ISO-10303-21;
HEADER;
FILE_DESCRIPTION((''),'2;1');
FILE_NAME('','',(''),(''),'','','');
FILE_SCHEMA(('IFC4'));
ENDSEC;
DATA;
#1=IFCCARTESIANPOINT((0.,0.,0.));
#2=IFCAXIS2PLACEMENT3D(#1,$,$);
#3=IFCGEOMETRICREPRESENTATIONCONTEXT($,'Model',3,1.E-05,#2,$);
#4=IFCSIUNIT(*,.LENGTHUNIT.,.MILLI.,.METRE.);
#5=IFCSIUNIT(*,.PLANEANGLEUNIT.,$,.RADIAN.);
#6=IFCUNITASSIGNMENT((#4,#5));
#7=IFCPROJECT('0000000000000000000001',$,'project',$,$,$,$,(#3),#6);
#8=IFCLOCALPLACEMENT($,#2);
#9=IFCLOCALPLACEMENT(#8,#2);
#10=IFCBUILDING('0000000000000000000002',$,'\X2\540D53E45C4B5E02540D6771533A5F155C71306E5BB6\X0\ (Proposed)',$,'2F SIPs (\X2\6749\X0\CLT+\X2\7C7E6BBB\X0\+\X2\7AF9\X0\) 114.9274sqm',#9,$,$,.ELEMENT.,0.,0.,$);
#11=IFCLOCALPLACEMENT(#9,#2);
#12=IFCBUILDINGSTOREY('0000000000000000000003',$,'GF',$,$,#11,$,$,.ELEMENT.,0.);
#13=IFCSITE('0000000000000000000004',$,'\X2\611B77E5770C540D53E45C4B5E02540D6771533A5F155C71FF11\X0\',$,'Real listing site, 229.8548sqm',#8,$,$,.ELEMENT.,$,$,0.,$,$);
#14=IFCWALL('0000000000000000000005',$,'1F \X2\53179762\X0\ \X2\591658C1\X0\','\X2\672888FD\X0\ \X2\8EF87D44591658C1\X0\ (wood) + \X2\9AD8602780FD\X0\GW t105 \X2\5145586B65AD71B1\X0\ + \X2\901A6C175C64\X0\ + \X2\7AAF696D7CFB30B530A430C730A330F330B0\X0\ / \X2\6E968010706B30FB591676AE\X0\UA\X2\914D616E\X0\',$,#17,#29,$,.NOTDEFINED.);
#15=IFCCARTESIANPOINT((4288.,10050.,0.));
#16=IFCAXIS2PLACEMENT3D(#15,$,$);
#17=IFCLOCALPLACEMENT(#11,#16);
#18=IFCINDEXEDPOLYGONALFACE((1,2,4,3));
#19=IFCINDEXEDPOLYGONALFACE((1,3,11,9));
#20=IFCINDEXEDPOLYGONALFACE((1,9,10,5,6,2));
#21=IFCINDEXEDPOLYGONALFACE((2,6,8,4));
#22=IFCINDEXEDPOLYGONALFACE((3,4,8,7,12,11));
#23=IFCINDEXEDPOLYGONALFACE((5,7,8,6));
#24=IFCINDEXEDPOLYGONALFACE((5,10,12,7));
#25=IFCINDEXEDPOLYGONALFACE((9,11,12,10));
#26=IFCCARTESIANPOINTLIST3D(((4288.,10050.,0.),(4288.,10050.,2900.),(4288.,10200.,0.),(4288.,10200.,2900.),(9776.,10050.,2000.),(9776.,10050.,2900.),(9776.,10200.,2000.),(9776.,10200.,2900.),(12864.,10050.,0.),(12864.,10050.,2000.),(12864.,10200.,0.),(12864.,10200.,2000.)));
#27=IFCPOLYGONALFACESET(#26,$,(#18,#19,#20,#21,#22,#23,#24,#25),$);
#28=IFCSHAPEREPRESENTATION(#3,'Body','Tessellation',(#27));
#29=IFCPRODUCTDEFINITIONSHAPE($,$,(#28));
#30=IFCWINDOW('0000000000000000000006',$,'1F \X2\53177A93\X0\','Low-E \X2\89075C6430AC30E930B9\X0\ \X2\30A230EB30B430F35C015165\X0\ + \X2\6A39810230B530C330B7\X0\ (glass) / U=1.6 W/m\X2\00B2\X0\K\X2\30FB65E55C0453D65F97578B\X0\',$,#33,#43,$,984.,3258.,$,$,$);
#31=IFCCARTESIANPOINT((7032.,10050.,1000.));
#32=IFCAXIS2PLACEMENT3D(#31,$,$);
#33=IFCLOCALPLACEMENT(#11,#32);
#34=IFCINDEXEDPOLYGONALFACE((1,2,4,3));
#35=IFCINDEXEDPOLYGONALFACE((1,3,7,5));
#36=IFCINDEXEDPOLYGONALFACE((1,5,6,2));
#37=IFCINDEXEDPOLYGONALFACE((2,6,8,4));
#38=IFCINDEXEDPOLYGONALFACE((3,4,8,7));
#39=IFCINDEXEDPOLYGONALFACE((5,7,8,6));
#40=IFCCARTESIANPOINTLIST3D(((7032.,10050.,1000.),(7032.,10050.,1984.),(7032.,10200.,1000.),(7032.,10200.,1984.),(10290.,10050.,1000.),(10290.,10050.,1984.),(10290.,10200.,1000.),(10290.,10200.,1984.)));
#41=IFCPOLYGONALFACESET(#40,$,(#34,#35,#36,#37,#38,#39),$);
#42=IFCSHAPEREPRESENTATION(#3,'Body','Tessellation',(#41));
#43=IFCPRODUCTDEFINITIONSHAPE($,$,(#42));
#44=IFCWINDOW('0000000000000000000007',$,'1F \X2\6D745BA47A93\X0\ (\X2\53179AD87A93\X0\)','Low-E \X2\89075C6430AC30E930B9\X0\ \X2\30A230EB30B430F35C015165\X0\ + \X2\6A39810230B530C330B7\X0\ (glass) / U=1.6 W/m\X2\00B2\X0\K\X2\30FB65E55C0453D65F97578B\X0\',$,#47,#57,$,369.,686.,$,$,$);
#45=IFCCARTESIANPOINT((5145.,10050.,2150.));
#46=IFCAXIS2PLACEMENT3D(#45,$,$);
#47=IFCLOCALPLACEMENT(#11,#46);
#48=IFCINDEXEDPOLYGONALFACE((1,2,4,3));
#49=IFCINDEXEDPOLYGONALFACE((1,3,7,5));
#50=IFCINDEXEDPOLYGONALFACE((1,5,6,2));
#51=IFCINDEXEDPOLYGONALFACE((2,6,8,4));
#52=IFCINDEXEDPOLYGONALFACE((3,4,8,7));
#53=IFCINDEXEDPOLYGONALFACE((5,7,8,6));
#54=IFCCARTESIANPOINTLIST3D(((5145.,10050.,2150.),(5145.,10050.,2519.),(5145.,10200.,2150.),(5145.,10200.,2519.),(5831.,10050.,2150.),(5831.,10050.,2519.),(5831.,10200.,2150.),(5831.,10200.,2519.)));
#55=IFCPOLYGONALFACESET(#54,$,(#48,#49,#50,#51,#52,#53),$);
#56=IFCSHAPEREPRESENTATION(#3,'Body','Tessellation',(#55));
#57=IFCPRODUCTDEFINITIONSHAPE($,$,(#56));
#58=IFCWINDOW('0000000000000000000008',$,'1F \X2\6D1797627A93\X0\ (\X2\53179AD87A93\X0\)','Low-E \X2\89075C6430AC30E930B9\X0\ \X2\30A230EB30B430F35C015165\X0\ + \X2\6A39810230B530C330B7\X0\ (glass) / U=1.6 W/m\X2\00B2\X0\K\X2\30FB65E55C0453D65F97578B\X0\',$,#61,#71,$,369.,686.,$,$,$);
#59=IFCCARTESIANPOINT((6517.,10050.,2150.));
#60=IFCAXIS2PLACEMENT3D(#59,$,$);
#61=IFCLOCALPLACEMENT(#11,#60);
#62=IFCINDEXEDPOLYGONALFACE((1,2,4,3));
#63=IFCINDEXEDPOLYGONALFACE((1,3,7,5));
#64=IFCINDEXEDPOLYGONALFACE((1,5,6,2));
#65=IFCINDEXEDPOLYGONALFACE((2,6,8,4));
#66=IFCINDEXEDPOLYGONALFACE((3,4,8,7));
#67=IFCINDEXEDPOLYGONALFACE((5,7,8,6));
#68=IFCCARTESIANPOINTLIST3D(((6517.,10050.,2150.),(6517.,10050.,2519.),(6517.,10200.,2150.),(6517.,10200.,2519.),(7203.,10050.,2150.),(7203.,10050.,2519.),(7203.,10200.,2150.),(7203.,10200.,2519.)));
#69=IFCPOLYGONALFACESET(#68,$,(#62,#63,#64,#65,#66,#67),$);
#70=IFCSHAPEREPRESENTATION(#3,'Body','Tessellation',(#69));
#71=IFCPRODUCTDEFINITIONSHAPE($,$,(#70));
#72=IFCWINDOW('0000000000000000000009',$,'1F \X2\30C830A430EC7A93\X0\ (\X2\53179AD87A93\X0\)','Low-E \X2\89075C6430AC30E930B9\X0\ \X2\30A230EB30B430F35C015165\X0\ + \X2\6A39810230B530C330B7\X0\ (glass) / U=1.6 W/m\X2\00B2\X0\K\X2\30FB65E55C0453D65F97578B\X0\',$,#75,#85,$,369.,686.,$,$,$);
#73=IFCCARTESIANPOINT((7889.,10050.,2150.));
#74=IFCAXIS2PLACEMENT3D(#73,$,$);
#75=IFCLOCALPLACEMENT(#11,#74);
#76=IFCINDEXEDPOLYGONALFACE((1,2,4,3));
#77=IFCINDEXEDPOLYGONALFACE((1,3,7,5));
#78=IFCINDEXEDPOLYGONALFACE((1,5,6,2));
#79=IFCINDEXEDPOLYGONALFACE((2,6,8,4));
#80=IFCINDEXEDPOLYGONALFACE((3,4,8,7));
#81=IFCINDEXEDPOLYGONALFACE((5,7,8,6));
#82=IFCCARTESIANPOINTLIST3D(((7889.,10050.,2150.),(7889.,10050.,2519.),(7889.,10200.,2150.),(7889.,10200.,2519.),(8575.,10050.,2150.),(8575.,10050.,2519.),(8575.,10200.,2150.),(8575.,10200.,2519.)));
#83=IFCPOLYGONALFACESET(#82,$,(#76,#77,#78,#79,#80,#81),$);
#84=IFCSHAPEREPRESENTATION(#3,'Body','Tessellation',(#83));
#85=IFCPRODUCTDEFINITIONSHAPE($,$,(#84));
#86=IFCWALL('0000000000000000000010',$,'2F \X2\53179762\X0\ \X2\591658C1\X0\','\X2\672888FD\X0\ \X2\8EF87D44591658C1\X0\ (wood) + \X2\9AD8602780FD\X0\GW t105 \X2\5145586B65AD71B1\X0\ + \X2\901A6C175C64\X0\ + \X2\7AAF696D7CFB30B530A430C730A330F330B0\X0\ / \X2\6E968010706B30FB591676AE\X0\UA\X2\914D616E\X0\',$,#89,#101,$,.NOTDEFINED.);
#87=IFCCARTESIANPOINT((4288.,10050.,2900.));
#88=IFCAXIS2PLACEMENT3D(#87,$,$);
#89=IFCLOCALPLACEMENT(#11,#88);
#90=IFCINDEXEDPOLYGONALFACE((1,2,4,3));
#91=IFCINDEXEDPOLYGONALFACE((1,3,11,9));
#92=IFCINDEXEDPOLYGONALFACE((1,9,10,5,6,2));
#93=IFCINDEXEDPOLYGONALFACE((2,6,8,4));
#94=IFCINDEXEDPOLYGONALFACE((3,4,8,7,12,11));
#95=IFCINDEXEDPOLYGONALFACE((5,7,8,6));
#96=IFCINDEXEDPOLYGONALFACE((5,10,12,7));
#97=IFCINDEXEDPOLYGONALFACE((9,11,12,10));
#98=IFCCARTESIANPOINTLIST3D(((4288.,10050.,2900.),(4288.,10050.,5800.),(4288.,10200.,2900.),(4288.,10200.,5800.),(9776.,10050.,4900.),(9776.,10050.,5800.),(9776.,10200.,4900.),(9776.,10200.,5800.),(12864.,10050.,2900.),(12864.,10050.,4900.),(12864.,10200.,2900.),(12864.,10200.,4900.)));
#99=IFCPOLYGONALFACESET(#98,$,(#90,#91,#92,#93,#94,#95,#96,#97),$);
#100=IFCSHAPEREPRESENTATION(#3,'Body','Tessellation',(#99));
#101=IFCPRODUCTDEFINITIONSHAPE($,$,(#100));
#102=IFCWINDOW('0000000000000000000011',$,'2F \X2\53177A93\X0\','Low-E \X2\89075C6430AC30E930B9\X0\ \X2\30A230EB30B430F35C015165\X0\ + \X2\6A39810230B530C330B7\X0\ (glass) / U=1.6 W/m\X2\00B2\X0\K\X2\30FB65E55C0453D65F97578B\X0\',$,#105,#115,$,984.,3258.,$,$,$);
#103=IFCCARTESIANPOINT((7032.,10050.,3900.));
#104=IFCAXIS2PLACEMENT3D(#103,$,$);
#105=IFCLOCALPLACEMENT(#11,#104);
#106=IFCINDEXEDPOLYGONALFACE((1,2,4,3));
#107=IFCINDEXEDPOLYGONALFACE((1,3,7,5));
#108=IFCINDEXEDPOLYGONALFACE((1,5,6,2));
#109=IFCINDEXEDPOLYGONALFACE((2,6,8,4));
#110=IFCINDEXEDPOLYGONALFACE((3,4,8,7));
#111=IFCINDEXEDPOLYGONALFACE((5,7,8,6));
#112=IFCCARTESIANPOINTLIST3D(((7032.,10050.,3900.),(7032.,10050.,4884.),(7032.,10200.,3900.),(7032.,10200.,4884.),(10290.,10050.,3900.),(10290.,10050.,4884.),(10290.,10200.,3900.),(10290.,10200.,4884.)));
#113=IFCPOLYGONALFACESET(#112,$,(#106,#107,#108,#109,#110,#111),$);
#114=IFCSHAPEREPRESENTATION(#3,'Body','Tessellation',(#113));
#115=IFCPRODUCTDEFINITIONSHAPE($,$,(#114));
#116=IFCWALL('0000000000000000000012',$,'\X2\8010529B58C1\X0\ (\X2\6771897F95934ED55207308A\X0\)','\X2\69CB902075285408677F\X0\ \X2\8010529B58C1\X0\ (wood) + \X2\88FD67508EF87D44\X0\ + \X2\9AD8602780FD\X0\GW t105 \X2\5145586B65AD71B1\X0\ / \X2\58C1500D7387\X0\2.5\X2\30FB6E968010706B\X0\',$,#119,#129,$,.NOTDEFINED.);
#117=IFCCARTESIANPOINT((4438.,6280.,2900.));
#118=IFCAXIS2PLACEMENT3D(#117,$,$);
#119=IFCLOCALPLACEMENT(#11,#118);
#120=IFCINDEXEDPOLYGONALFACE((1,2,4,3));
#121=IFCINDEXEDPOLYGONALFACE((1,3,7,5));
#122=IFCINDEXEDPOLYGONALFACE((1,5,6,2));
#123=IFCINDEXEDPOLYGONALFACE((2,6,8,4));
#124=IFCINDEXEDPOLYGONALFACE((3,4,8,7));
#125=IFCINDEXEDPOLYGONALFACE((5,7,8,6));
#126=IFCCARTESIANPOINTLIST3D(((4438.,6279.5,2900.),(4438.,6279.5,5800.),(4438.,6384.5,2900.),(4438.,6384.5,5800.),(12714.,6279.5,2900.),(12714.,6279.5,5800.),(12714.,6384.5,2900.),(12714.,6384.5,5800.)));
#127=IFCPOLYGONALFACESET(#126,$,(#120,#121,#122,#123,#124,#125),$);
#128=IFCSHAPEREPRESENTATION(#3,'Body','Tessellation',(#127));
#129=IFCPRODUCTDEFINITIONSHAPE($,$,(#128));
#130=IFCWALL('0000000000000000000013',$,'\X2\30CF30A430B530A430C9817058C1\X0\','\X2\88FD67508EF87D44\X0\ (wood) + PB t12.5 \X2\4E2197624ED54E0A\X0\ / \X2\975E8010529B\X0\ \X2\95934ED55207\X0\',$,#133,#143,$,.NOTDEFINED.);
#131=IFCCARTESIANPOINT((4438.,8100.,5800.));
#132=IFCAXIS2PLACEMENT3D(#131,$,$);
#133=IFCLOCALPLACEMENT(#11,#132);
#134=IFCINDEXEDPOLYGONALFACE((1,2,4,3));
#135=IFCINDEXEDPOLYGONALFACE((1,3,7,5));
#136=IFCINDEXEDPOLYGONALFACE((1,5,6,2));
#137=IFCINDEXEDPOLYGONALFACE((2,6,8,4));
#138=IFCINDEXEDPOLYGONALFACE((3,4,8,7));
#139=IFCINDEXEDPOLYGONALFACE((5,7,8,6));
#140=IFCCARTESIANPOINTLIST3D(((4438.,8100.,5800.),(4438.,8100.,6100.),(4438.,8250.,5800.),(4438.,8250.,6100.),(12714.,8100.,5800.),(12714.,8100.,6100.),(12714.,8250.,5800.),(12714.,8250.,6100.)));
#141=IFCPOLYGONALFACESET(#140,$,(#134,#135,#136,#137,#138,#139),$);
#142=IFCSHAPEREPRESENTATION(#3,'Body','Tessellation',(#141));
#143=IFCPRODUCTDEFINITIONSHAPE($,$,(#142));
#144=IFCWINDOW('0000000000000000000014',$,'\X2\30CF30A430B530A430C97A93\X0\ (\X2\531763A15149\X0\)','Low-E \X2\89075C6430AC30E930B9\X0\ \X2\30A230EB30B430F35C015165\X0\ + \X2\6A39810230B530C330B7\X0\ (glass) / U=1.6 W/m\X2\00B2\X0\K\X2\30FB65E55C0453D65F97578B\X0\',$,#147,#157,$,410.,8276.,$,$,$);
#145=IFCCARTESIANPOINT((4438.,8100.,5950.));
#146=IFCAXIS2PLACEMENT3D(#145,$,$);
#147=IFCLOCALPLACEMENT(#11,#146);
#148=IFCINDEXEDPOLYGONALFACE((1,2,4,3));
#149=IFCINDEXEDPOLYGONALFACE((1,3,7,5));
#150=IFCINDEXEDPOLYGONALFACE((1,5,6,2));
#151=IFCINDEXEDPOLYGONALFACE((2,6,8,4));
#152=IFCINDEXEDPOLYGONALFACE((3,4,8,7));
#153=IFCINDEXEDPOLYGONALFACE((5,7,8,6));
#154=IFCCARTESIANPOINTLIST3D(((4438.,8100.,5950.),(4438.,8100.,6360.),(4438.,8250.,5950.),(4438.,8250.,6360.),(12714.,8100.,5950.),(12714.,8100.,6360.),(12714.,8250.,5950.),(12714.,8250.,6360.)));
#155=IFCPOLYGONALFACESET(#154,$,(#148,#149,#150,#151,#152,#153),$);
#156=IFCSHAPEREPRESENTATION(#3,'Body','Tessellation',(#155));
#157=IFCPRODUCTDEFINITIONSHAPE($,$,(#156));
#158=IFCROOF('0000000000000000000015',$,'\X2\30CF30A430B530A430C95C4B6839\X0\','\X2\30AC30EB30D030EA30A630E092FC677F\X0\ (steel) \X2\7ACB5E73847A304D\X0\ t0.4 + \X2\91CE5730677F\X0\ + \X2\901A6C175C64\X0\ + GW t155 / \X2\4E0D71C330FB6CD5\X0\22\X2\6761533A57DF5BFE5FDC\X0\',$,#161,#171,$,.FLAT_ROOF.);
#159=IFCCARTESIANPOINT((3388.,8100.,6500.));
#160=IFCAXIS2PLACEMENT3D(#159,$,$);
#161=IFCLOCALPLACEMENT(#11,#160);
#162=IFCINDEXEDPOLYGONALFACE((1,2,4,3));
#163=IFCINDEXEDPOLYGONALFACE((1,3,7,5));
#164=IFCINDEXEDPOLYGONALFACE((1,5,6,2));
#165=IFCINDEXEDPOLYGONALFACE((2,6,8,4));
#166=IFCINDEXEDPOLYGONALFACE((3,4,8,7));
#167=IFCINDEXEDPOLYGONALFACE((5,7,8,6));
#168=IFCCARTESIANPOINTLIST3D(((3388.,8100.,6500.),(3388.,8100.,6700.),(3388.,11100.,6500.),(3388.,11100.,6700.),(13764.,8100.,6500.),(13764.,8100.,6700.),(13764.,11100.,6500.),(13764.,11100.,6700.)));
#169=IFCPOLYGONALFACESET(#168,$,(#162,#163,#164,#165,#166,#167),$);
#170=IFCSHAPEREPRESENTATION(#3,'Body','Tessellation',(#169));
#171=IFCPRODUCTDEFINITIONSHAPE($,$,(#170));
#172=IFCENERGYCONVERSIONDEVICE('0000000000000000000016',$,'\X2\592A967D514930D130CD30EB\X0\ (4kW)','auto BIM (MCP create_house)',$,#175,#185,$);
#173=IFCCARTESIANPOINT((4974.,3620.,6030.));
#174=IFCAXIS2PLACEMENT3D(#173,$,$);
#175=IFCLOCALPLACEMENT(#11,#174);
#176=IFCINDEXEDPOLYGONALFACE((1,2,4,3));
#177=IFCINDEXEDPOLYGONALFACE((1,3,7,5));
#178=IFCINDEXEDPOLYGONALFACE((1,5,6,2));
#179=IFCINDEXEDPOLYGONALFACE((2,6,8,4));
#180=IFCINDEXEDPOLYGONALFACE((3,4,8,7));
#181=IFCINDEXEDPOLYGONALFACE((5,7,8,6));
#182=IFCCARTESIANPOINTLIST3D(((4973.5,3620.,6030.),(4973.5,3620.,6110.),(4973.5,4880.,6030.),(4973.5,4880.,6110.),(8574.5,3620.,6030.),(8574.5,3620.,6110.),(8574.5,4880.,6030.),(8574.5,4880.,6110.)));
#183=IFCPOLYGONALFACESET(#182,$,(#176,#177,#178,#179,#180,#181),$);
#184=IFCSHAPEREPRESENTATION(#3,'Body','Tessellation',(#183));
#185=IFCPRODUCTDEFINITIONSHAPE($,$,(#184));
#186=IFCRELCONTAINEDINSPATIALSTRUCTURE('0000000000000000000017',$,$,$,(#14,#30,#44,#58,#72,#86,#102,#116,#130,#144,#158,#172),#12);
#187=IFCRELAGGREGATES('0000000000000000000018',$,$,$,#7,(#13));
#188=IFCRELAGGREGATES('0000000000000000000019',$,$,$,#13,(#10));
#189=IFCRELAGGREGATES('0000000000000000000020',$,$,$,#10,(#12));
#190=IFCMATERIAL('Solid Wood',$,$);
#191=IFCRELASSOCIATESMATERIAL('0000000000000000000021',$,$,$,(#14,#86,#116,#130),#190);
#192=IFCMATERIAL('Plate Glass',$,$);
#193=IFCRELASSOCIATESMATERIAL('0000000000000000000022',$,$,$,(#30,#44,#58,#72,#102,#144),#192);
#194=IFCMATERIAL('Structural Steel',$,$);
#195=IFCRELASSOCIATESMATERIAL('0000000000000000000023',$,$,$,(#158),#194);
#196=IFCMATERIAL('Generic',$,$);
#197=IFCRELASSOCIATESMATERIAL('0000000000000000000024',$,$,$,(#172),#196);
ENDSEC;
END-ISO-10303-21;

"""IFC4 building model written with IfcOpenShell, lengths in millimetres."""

from ifc_helpers import new_model, si_unit, frame, frame_2d, origin, place, context, project, spatial, rectangle, extrude, material, element, fill, save


model = new_model("IFC4")

# Units and contexts
model_context = context("Model", 3, precision=1e-05, world=origin())
ifc_project = project(units=[si_unit("LENGTHUNIT", "METRE", prefix="MILLI"), si_unit("PLANEANGLEUNIT", "RADIAN")], contexts=[model_context])

# Site, building, storey
site_placement = place(None, origin())
site = spatial("IfcSite", under=ifc_project, at=site_placement, Name="愛知県名古屋市名東区引山１", ObjectType="Real listing site, 229.8548sqm", CompositionType="ELEMENT", RefElevation=0.0)
building_placement = place(site_placement, origin())
building = spatial("IfcBuilding", under=site, at=building_placement, Name="名古屋市名東区引山の家 (Proposed)", ObjectType="2F SIPs (杉CLT+籾殻+竹) 114.9274sqm", CompositionType="ELEMENT", ElevationOfRefHeight=0.0, ElevationOfTerrain=0.0)
storey_placement = place(building_placement, origin())
storey = spatial("IfcBuildingStorey", under=building, at=storey_placement, Name="GF", CompositionType="ELEMENT", Elevation=0.0)

# Wall, openings, windows
ifc_material_1 = material(Name="Solid Wood")
wall_1_placement = place(storey_placement, frame((4288.0, 10050.0, 0.0)))
wall_1 = element("IfcWall", 1, at=wall_1_placement, inside=storey, material=ifc_material_1, Name="1F 北面 外壁", Description="木製 軸組外壁 (wood) + 高性能GW t105 充填断熱 + 通気層 + 窯業系サイディング / 準耐火・外皮UA配慮", PredefinedType="NOTDEFINED", context=model_context, shape_type="SweptSolid", body=[
    extrude(rectangle(XDim=8576.0, YDim=150.0, at=frame_2d((4288.0, 75.0))), frame((4288.0, 10050.0, 0.0)), (0.0, 0.0, 1.0), 2900.0),
])
opening_1_placement = place(storey_placement, frame((7032.0, 10050.0, 1000.0)))
opening_1 = element("IfcOpeningElement", 2, at=opening_1_placement, cuts=wall_1, PredefinedType="NOTDEFINED", context=model_context, shape_type="SweptSolid", body=[
    extrude(rectangle(XDim=3258.0, YDim=150.0, at=frame_2d((1629.0, 75.0))), frame((7032.0, 10050.0, 1000.0)), (0.0, 0.0, 1.0), 984.0),
])
opening_2_placement = place(storey_placement, frame((5145.0, 10050.0, 2150.0)))
opening_2 = element("IfcOpeningElement", 3, at=opening_2_placement, cuts=wall_1, PredefinedType="NOTDEFINED", context=model_context, shape_type="SweptSolid", body=[
    extrude(rectangle(XDim=686.0, YDim=150.0, at=frame_2d((343.0, 75.0))), frame((5145.0, 10050.0, 2150.0)), (0.0, 0.0, 1.0), 369.0),
])
opening_3_placement = place(storey_placement, frame((6517.0, 10050.0, 2150.0)))
opening_3 = element("IfcOpeningElement", 4, at=opening_3_placement, cuts=wall_1, PredefinedType="NOTDEFINED", context=model_context, shape_type="SweptSolid", body=[
    extrude(rectangle(XDim=686.0, YDim=150.0, at=frame_2d((343.0, 75.0))), frame((6517.0, 10050.0, 2150.0)), (0.0, 0.0, 1.0), 369.0),
])
opening_4_placement = place(storey_placement, frame((7889.0, 10050.0, 2150.0)))
opening_4 = element("IfcOpeningElement", 5, at=opening_4_placement, cuts=wall_1, PredefinedType="NOTDEFINED", context=model_context, shape_type="SweptSolid", body=[
    extrude(rectangle(XDim=686.0, YDim=150.0, at=frame_2d((343.0, 75.0))), frame((7889.0, 10050.0, 2150.0)), (0.0, 0.0, 1.0), 369.0),
])
ifc_material_2 = material(Name="Plate Glass")
window_1_placement = place(storey_placement, frame((7032.0, 10050.0, 1000.0)))
window_1 = element("IfcWindow", 6, at=window_1_placement, inside=storey, material=ifc_material_2, Name="1F 北窓", Description="Low-E 複層ガラス アルゴン封入 + 樹脂サッシ (glass) / U=1.6 W/m²K・日射取得型", OverallHeight=984.0, OverallWidth=3258.0, context=model_context, shape_type="SweptSolid", body=[
    extrude(rectangle(XDim=3258.0, YDim=150.0, at=frame_2d((1629.0, 75.0))), frame((7032.0, 10050.0, 1000.0)), (0.0, 0.0, 1.0), 984.0),
])
fill(opening_1, window_1)
window_2_placement = place(storey_placement, frame((5145.0, 10050.0, 2150.0)))
window_2 = element("IfcWindow", 7, at=window_2_placement, inside=storey, material=ifc_material_2, Name="1F 浴室窓 (北高窓)", Description="Low-E 複層ガラス アルゴン封入 + 樹脂サッシ (glass) / U=1.6 W/m²K・日射取得型", OverallHeight=369.0, OverallWidth=686.0, context=model_context, shape_type="SweptSolid", body=[
    extrude(rectangle(XDim=686.0, YDim=150.0, at=frame_2d((343.0, 75.0))), frame((5145.0, 10050.0, 2150.0)), (0.0, 0.0, 1.0), 369.0),
])
fill(opening_2, window_2)
window_3_placement = place(storey_placement, frame((6517.0, 10050.0, 2150.0)))
window_3 = element("IfcWindow", 8, at=window_3_placement, inside=storey, material=ifc_material_2, Name="1F 洗面窓 (北高窓)", Description="Low-E 複層ガラス アルゴン封入 + 樹脂サッシ (glass) / U=1.6 W/m²K・日射取得型", OverallHeight=369.0, OverallWidth=686.0, context=model_context, shape_type="SweptSolid", body=[
    extrude(rectangle(XDim=686.0, YDim=150.0, at=frame_2d((343.0, 75.0))), frame((6517.0, 10050.0, 2150.0)), (0.0, 0.0, 1.0), 369.0),
])
fill(opening_3, window_3)
window_4_placement = place(storey_placement, frame((7889.0, 10050.0, 2150.0)))
window_4 = element("IfcWindow", 9, at=window_4_placement, inside=storey, material=ifc_material_2, Name="1F トイレ窓 (北高窓)", Description="Low-E 複層ガラス アルゴン封入 + 樹脂サッシ (glass) / U=1.6 W/m²K・日射取得型", OverallHeight=369.0, OverallWidth=686.0, context=model_context, shape_type="SweptSolid", body=[
    extrude(rectangle(XDim=686.0, YDim=150.0, at=frame_2d((343.0, 75.0))), frame((7889.0, 10050.0, 2150.0)), (0.0, 0.0, 1.0), 369.0),
])
fill(opening_4, window_4)

# Wall, opening, window
wall_2_placement = place(storey_placement, frame((4288.0, 10050.0, 2900.0)))
wall_2 = element("IfcWall", 10, at=wall_2_placement, inside=storey, material=ifc_material_1, Name="2F 北面 外壁", Description="木製 軸組外壁 (wood) + 高性能GW t105 充填断熱 + 通気層 + 窯業系サイディング / 準耐火・外皮UA配慮", PredefinedType="NOTDEFINED", context=model_context, shape_type="SweptSolid", body=[
    extrude(rectangle(XDim=8576.0, YDim=150.0, at=frame_2d((4288.0, 75.0))), frame((4288.0, 10050.0, 2900.0)), (0.0, 0.0, 1.0), 2900.0),
])
opening_5_placement = place(storey_placement, frame((7032.0, 10050.0, 3900.0)))
opening_5 = element("IfcOpeningElement", 11, at=opening_5_placement, cuts=wall_2, PredefinedType="NOTDEFINED", context=model_context, shape_type="SweptSolid", body=[
    extrude(rectangle(XDim=3258.0, YDim=150.0, at=frame_2d((1629.0, 75.0))), frame((7032.0, 10050.0, 3900.0)), (0.0, 0.0, 1.0), 984.0),
])
window_5_placement = place(storey_placement, frame((7032.0, 10050.0, 3900.0)))
window_5 = element("IfcWindow", 12, at=window_5_placement, inside=storey, material=ifc_material_2, Name="2F 北窓", Description="Low-E 複層ガラス アルゴン封入 + 樹脂サッシ (glass) / U=1.6 W/m²K・日射取得型", OverallHeight=984.0, OverallWidth=3258.0, context=model_context, shape_type="SweptSolid", body=[
    extrude(rectangle(XDim=3258.0, YDim=150.0, at=frame_2d((1629.0, 75.0))), frame((7032.0, 10050.0, 3900.0)), (0.0, 0.0, 1.0), 984.0),
])
fill(opening_5, window_5)

# Wall
wall_3_placement = place(storey_placement, frame((4438.0, 6280.0, 2900.0)))
element("IfcWall", 13, at=wall_3_placement, inside=storey, material=ifc_material_1, Name="耐力壁 (東西間仕切り)", Description="構造用合板 耐力壁 (wood) + 製材軸組 + 高性能GW t105 充填断熱 / 壁倍率2.5・準耐火", PredefinedType="NOTDEFINED", context=model_context, shape_type="SweptSolid", body=[
    extrude(rectangle(XDim=8276.0, YDim=105.0, at=frame_2d((4138.0, 52.0))), frame((4438.0, 6280.0, 2900.0)), (0.0, 0.0, 1.0), 2900.0),
])

# Wall, opening, window
wall_4_placement = place(storey_placement, frame((4438.0, 8100.0, 5800.0)))
wall_4 = element("IfcWall", 14, at=wall_4_placement, inside=storey, material=ifc_material_1, Name="ハイサイド腰壁", Description="製材軸組 (wood) + PB t12.5 両面仕上 / 非耐力 間仕切", PredefinedType="NOTDEFINED", context=model_context, shape_type="SweptSolid", body=[
    extrude(rectangle(XDim=8276.0, YDim=150.0, at=frame_2d((4138.0, 75.0))), frame((4438.0, 8100.0, 5800.0)), (0.0, 0.0, 1.0), 700.0),
])
opening_6_placement = place(storey_placement, frame((4438.0, 8100.0, 5950.0)))
opening_6 = element("IfcOpeningElement", 15, at=opening_6_placement, cuts=wall_4, PredefinedType="NOTDEFINED", context=model_context, shape_type="SweptSolid", body=[
    extrude(rectangle(XDim=8276.0, YDim=150.0, at=frame_2d((4138.0, 75.0))), frame((4438.0, 8100.0, 5950.0)), (0.0, 0.0, 1.0), 410.0),
])
window_6_placement = place(storey_placement, frame((4438.0, 8100.0, 5950.0)))
window_6 = element("IfcWindow", 16, at=window_6_placement, inside=storey, material=ifc_material_2, Name="ハイサイド窓 (北採光)", Description="Low-E 複層ガラス アルゴン封入 + 樹脂サッシ (glass) / U=1.6 W/m²K・日射取得型", OverallHeight=410.0, OverallWidth=8276.0, context=model_context, shape_type="SweptSolid", body=[
    extrude(rectangle(XDim=8276.0, YDim=150.0, at=frame_2d((4138.0, 75.0))), frame((4438.0, 8100.0, 5950.0)), (0.0, 0.0, 1.0), 410.0),
])
fill(opening_6, window_6)

# Roof
ifc_material_3 = material(Name="Structural Steel")
roof_placement = place(storey_placement, frame((3388.0, 8100.0, 6500.0)))
element("IfcRoof", 17, at=roof_placement, inside=storey, material=ifc_material_3, Name="ハイサイド屋根", Description="ガルバリウム鋼板 (steel) 立平葺き t0.4 + 野地板 + 通気層 + GW t155 / 不燃・法22条区域対応", PredefinedType="FLAT_ROOF", context=model_context, shape_type="SweptSolid", body=[
    extrude(rectangle(XDim=10376.0, YDim=3000.0, at=frame_2d((5188.0, 1500.0))), frame((3388.0, 8100.0, 6500.0)), (0.0, 0.0, 1.0), 200.0),
])

# Energy conversion device
ifc_material_4 = material(Name="Generic")
energy_conversion_device_placement = place(storey_placement, frame((4974.0, 3620.0, 6030.0)))
element("IfcEnergyConversionDevice", 18, at=energy_conversion_device_placement, inside=storey, material=ifc_material_4, Name="太陽光パネル (4kW)", Description="auto BIM (MCP create_house)", context=model_context, shape_type="SweptSolid", body=[
    extrude(rectangle(XDim=3601.0, YDim=1260.0, at=frame_2d((1800.0, 630.0))), frame((4974.0, 3620.0, 6030.0)), (0.0, 0.0, 1.0), 80.0),
])

save(model, "model.ifc")
